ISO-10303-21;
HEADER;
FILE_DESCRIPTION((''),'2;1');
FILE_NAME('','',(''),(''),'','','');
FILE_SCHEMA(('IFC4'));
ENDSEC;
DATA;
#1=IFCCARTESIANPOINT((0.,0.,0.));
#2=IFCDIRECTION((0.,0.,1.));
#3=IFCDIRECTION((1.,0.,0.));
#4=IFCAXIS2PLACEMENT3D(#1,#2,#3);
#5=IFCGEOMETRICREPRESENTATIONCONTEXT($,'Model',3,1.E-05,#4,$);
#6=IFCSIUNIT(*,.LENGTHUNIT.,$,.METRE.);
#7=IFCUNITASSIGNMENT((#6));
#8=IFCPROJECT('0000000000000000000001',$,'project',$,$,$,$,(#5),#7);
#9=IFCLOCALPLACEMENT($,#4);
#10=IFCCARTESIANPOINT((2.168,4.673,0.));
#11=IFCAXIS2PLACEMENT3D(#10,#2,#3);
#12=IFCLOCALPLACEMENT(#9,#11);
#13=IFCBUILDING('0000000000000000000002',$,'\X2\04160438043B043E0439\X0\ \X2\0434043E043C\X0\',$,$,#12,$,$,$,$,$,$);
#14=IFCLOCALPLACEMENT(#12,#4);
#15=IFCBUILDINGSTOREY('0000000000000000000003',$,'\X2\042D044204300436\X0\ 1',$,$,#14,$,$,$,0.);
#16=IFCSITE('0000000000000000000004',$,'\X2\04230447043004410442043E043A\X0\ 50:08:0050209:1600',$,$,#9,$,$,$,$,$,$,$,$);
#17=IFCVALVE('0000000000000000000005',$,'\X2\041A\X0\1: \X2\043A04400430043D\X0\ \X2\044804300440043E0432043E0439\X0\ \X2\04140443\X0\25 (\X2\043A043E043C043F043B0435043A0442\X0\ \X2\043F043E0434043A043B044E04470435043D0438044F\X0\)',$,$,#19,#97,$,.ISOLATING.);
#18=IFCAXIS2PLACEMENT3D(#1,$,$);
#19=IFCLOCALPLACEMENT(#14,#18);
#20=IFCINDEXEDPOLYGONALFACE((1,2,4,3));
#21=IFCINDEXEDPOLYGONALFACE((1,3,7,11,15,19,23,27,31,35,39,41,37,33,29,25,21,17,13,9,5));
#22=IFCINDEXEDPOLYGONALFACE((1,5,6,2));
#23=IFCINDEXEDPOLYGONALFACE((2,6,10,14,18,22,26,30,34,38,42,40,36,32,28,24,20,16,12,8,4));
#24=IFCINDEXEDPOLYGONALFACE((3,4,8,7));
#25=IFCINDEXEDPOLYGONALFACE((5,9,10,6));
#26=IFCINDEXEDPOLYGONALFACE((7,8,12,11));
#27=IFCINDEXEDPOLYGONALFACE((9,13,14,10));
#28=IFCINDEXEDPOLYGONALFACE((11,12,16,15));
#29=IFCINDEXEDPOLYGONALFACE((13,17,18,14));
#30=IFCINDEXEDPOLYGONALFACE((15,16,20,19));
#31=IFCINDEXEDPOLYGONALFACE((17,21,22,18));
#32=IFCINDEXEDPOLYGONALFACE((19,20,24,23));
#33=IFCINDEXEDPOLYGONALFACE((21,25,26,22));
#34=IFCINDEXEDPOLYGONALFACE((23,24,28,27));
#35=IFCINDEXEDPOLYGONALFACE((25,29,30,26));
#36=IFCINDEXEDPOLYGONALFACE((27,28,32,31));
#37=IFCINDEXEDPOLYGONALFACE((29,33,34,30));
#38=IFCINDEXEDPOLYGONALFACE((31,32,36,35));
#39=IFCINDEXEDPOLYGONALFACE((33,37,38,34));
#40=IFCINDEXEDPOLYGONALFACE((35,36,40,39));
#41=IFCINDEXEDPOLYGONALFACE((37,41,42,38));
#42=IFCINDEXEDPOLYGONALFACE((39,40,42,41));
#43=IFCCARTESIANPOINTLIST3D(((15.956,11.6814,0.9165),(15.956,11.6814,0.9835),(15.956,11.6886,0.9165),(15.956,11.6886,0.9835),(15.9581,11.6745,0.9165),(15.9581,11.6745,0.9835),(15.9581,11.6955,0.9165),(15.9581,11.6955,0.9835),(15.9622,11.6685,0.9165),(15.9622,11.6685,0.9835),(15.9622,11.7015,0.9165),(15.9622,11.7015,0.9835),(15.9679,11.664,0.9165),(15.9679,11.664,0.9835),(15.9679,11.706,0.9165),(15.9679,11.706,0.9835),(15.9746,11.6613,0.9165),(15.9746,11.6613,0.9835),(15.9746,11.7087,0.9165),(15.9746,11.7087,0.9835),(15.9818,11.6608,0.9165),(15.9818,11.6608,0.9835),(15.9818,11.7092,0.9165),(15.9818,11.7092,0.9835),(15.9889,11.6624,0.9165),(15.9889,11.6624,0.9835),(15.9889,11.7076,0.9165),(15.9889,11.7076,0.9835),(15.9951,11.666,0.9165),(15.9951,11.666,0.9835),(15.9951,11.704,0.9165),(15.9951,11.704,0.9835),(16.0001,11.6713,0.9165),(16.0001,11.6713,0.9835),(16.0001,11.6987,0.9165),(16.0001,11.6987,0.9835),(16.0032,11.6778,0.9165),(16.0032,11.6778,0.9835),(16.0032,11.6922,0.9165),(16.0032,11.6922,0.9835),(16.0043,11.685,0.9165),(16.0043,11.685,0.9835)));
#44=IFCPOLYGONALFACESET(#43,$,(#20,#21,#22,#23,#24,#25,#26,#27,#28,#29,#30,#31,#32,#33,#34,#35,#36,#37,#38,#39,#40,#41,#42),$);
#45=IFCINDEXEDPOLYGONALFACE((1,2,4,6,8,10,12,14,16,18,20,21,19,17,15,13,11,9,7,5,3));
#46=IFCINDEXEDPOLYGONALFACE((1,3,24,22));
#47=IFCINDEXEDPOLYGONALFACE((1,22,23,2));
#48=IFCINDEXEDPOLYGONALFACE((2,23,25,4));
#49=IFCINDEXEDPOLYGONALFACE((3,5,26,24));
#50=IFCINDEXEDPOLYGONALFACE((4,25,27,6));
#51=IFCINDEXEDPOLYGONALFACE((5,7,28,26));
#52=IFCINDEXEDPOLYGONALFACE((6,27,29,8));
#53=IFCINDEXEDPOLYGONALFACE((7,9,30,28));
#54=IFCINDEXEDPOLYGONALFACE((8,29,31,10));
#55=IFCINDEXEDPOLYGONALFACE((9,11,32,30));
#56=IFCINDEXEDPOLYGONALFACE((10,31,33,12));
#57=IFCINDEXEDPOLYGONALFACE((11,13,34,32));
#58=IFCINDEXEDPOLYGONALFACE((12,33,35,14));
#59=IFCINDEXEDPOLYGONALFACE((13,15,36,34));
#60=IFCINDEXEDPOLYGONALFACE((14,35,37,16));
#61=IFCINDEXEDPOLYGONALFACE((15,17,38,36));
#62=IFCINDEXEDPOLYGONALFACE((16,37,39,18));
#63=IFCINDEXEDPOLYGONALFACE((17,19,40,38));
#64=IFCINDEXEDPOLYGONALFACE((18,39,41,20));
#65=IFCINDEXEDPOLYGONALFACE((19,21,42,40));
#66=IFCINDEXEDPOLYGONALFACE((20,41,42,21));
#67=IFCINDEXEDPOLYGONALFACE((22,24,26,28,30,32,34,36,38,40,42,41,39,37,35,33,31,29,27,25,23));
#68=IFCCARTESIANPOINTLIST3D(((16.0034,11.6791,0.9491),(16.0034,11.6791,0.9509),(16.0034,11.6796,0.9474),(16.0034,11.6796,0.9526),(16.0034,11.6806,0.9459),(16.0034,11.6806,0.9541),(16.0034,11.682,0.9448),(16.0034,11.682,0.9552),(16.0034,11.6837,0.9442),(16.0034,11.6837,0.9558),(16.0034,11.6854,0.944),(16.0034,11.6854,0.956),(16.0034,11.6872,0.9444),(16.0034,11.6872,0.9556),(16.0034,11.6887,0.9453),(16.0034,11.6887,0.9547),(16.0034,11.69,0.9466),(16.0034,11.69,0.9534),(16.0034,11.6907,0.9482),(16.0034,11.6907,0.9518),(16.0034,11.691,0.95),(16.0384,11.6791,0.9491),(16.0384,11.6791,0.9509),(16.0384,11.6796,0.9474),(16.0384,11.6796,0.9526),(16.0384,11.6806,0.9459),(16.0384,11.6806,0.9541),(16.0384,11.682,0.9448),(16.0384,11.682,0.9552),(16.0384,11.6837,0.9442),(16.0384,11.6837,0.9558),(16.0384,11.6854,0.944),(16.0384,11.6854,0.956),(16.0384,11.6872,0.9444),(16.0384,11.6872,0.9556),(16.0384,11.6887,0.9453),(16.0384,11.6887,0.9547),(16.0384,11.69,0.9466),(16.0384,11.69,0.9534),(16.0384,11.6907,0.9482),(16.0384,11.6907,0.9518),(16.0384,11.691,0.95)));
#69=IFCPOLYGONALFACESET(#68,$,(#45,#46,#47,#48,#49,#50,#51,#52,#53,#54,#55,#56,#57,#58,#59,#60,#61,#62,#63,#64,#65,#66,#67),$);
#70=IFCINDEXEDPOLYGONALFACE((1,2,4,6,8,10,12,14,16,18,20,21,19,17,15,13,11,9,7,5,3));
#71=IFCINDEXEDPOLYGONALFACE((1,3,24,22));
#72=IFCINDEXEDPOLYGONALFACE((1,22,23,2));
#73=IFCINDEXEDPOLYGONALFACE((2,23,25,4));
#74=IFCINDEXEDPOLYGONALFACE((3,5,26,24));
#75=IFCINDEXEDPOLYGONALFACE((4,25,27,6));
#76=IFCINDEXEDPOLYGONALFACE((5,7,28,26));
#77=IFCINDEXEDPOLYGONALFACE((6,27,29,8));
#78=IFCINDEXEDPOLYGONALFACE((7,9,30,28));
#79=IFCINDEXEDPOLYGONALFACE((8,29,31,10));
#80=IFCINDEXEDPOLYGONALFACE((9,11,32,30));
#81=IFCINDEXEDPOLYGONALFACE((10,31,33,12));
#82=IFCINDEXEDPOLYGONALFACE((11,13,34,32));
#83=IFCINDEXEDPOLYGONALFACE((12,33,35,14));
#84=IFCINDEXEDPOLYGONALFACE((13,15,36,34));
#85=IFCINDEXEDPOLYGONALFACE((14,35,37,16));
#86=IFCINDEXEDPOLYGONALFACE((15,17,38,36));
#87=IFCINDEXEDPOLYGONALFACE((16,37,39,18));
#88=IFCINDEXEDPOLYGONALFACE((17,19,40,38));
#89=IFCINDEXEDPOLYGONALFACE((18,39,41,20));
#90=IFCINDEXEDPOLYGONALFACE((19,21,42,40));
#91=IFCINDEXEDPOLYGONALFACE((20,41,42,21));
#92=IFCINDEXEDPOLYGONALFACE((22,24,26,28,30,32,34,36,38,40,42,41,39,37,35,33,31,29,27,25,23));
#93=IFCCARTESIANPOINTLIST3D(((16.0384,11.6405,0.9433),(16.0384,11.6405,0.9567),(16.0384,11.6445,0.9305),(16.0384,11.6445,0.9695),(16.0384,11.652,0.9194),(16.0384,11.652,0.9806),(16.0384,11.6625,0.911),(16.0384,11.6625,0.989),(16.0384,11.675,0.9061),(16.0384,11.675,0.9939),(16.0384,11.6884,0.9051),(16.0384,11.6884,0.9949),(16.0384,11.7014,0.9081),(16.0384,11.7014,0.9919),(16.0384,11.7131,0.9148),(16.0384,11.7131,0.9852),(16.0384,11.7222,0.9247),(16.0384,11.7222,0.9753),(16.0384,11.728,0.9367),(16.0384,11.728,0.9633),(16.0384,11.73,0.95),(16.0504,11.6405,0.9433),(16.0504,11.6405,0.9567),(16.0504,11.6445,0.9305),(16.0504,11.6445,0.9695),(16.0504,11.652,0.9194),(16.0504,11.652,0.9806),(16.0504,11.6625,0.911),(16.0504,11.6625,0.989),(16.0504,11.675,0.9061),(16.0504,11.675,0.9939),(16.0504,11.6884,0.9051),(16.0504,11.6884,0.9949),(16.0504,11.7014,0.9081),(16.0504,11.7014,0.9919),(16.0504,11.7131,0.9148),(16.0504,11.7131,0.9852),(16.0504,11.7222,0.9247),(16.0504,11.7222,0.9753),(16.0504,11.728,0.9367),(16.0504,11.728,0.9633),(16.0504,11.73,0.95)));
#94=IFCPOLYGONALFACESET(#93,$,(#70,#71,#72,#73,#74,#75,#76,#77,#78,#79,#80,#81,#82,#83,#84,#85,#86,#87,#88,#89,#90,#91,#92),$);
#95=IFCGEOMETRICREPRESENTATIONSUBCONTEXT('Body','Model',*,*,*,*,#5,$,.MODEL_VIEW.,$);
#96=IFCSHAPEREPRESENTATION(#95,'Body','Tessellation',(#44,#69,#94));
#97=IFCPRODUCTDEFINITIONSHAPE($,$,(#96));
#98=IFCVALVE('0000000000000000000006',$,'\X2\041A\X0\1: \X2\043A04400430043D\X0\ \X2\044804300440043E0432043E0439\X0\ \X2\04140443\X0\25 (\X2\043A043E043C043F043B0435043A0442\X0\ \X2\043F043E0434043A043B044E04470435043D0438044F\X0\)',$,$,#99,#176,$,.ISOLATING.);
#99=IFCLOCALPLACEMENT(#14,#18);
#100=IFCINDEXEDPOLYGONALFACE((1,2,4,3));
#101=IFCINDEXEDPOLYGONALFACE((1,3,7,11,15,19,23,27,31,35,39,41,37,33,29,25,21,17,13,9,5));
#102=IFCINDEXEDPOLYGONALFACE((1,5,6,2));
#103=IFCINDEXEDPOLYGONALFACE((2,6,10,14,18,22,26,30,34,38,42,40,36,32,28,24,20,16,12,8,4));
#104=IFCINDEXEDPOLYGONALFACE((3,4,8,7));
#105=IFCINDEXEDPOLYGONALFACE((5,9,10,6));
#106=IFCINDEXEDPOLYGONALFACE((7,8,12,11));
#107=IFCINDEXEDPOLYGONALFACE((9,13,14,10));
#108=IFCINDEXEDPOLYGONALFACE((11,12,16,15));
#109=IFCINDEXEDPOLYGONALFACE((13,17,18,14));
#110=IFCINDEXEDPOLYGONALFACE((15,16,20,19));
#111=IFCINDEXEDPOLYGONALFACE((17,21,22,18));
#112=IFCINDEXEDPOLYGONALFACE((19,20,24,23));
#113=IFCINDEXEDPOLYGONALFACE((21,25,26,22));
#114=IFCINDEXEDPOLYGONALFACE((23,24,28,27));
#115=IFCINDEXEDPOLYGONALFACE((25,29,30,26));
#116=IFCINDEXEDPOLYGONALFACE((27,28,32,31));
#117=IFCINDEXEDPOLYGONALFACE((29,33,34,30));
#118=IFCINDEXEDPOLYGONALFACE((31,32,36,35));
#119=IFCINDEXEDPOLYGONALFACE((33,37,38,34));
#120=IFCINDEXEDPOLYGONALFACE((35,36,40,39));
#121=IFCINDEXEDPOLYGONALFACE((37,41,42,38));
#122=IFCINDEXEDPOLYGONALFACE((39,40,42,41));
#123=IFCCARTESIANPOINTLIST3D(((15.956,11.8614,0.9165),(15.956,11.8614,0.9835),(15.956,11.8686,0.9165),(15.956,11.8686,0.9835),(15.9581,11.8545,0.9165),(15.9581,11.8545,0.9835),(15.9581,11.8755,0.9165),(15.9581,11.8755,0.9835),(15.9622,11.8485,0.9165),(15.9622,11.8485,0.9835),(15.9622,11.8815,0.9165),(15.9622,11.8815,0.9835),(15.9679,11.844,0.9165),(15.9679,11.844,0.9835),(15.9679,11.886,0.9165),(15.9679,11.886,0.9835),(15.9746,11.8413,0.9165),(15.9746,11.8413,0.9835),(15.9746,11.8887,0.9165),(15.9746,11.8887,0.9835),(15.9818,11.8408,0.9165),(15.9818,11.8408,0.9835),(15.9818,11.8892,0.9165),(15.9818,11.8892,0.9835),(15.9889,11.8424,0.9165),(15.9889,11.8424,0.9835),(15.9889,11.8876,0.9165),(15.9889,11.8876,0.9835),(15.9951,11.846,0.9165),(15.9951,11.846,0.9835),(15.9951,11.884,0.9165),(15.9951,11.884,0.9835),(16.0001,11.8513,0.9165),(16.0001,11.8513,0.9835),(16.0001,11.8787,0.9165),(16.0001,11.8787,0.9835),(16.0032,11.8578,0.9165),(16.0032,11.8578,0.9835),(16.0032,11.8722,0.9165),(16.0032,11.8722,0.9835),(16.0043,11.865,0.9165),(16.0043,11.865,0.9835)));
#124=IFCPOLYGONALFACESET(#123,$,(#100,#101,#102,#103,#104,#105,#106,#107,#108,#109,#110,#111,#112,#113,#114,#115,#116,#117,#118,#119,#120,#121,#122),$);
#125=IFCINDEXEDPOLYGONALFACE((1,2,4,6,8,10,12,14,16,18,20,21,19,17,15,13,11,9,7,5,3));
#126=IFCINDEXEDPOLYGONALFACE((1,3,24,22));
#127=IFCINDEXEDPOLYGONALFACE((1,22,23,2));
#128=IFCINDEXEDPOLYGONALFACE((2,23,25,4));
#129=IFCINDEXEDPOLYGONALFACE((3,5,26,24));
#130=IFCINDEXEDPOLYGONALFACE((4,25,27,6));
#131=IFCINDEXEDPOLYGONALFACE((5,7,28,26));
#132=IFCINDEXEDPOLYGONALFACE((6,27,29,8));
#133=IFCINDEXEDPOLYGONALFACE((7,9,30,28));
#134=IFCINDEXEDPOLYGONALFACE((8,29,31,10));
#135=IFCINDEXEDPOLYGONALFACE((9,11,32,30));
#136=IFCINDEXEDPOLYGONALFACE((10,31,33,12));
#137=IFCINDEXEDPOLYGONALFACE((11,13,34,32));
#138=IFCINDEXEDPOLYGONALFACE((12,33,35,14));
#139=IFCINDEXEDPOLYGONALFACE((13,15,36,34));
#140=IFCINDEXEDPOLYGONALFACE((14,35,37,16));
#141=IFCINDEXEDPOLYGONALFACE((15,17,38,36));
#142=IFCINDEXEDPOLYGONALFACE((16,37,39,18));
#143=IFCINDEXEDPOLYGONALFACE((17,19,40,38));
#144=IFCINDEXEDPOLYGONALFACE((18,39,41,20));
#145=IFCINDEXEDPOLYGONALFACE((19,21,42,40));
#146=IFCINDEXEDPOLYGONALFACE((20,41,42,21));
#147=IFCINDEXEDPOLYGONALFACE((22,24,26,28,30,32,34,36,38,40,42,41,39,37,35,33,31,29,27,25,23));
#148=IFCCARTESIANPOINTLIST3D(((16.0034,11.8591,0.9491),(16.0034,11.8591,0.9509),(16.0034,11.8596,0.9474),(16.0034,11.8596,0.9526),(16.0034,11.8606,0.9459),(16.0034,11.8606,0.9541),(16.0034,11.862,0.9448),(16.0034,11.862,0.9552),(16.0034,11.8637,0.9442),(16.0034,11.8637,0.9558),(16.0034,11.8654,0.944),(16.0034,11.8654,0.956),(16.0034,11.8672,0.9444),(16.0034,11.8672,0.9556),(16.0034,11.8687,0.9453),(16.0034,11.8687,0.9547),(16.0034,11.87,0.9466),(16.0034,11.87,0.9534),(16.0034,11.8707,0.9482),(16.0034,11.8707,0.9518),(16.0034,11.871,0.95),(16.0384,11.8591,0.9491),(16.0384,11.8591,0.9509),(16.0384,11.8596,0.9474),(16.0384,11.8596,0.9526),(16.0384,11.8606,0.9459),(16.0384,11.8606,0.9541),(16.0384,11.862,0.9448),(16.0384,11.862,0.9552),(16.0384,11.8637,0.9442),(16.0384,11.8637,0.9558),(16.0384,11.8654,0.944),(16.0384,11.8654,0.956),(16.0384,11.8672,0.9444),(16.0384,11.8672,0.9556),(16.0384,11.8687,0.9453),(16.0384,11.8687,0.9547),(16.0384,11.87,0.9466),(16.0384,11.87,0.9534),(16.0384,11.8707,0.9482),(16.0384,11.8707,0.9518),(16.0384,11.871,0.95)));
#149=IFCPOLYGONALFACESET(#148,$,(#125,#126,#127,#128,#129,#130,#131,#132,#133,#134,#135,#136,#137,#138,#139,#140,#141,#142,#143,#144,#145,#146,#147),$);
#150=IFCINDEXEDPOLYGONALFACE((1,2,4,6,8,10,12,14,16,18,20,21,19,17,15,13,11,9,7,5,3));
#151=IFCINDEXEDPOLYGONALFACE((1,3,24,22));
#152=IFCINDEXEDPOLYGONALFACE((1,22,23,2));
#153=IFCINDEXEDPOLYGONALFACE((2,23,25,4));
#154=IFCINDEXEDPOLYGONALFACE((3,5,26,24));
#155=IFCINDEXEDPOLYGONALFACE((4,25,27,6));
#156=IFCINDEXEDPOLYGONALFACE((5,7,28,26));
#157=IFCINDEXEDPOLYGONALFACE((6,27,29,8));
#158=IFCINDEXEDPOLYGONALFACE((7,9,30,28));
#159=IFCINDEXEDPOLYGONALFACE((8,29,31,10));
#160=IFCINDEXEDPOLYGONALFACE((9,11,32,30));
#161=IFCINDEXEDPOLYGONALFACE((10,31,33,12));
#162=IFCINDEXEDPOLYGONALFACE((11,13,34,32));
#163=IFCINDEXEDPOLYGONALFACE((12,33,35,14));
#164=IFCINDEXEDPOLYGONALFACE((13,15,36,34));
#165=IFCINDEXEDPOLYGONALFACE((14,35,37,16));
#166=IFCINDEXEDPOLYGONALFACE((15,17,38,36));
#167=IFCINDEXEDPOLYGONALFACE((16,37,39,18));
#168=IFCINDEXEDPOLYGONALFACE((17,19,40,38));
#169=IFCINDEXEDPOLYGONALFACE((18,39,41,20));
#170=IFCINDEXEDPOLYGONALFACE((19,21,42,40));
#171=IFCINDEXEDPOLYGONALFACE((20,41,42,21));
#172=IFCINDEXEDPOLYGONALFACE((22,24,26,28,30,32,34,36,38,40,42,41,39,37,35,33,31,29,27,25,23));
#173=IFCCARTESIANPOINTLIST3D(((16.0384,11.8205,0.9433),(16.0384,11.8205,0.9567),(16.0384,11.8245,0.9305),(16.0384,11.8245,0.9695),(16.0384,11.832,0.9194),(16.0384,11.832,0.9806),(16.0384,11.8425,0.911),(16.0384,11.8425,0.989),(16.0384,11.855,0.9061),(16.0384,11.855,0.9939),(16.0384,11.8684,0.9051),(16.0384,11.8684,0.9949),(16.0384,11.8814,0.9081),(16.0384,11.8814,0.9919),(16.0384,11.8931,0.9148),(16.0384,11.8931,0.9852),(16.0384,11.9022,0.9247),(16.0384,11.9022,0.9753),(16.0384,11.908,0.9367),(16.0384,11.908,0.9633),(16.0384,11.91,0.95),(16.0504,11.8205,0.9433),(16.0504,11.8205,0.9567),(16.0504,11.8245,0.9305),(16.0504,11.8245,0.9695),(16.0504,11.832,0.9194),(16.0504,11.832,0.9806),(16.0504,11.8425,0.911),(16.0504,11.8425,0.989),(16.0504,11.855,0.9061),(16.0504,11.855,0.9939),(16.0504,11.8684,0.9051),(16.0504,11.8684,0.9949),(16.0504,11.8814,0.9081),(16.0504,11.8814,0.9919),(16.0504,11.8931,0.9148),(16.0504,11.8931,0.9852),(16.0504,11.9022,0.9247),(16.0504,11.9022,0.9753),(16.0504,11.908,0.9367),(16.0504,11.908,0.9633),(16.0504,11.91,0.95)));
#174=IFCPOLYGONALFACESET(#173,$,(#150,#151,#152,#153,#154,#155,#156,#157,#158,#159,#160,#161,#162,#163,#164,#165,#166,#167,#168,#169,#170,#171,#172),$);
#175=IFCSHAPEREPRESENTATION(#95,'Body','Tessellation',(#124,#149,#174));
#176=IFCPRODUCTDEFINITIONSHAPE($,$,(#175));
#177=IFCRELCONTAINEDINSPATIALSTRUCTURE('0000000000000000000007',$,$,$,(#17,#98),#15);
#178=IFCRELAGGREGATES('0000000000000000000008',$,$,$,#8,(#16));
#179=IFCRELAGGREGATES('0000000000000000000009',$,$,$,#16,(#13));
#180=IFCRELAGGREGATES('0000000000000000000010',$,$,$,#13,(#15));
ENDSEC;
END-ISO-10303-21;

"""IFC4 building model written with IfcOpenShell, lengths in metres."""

from ifc_helpers import new_model, si_unit, frame, origin_with_axes, origin_2d, place, context, subcontext, project, spatial, circle, extrude, element, save


model = new_model("IFC4")

# Units and contexts
model_context = context("Model", 3, precision=1e-05, world=origin_with_axes())
body_context = subcontext(model_context, "Body", "Model", "MODEL_VIEW")
ifc_project = project(units=[si_unit("LENGTHUNIT", "METRE")], contexts=[model_context])

# Site, building, storey
site_placement = place(None, origin_with_axes())
site = spatial("IfcSite", under=ifc_project, at=site_placement, Name="Участок 50:08:0050209:1600")
building_placement = place(site_placement, frame((2.168, 4.673, 0.0), z_axis=(0.0, 0.0, 1.0), x_axis=(1.0, 0.0, 0.0)))
building = spatial("IfcBuilding", under=site, at=building_placement, Name="Жилой дом")
storey_placement = place(building_placement, origin_with_axes())
storey = spatial("IfcBuildingStorey", under=building, at=storey_placement, Name="Этаж 1", Elevation=0.0)

# Valves
valve_1_placement = place(storey_placement, origin_with_axes())
element("IfcValve", 1, at=valve_1_placement, inside=storey, Name="К1: кран шаровой Ду25 (комплект подключения)", PredefinedType="ISOLATING", context=body_context, shape_type="SweptSolid", body=[
    extrude(circle(Radius=0.0243, at=origin_2d()), frame((15.98, 11.685, 0.9165), z_axis=(0.0, 0.0, 1.0), x_axis=(1.0, 0.0, 0.0)), (0.0, 0.0, 1.0), 0.067),
    extrude(circle(Radius=0.006, at=origin_2d()), frame((16.0035, 11.685, 0.95), z_axis=(1.0, 0.0, 0.0), x_axis=(0.0, 1.0, 0.0)), (0.0, 0.0, 1.0), 0.035),
    extrude(circle(Radius=0.045, at=origin_2d()), frame((16.0385, 11.685, 0.95), z_axis=(1.0, 0.0, 0.0), x_axis=(0.0, 1.0, 0.0)), (0.0, 0.0, 1.0), 0.012),
])
valve_2_placement = place(storey_placement, origin_with_axes())
element("IfcValve", 2, at=valve_2_placement, inside=storey, Name="К1: кран шаровой Ду25 (комплект подключения)", PredefinedType="ISOLATING", context=body_context, shape_type="SweptSolid", body=[
    extrude(circle(Radius=0.0243, at=origin_2d()), frame((15.98, 11.865, 0.9165), z_axis=(0.0, 0.0, 1.0), x_axis=(1.0, 0.0, 0.0)), (0.0, 0.0, 1.0), 0.067),
    extrude(circle(Radius=0.006, at=origin_2d()), frame((16.0035, 11.865, 0.95), z_axis=(1.0, 0.0, 0.0), x_axis=(0.0, 1.0, 0.0)), (0.0, 0.0, 1.0), 0.035),
    extrude(circle(Radius=0.045, at=origin_2d()), frame((16.0385, 11.865, 0.95), z_axis=(1.0, 0.0, 0.0), x_axis=(0.0, 1.0, 0.0)), (0.0, 0.0, 1.0), 0.012),
])

save(model, "model.ifc")
